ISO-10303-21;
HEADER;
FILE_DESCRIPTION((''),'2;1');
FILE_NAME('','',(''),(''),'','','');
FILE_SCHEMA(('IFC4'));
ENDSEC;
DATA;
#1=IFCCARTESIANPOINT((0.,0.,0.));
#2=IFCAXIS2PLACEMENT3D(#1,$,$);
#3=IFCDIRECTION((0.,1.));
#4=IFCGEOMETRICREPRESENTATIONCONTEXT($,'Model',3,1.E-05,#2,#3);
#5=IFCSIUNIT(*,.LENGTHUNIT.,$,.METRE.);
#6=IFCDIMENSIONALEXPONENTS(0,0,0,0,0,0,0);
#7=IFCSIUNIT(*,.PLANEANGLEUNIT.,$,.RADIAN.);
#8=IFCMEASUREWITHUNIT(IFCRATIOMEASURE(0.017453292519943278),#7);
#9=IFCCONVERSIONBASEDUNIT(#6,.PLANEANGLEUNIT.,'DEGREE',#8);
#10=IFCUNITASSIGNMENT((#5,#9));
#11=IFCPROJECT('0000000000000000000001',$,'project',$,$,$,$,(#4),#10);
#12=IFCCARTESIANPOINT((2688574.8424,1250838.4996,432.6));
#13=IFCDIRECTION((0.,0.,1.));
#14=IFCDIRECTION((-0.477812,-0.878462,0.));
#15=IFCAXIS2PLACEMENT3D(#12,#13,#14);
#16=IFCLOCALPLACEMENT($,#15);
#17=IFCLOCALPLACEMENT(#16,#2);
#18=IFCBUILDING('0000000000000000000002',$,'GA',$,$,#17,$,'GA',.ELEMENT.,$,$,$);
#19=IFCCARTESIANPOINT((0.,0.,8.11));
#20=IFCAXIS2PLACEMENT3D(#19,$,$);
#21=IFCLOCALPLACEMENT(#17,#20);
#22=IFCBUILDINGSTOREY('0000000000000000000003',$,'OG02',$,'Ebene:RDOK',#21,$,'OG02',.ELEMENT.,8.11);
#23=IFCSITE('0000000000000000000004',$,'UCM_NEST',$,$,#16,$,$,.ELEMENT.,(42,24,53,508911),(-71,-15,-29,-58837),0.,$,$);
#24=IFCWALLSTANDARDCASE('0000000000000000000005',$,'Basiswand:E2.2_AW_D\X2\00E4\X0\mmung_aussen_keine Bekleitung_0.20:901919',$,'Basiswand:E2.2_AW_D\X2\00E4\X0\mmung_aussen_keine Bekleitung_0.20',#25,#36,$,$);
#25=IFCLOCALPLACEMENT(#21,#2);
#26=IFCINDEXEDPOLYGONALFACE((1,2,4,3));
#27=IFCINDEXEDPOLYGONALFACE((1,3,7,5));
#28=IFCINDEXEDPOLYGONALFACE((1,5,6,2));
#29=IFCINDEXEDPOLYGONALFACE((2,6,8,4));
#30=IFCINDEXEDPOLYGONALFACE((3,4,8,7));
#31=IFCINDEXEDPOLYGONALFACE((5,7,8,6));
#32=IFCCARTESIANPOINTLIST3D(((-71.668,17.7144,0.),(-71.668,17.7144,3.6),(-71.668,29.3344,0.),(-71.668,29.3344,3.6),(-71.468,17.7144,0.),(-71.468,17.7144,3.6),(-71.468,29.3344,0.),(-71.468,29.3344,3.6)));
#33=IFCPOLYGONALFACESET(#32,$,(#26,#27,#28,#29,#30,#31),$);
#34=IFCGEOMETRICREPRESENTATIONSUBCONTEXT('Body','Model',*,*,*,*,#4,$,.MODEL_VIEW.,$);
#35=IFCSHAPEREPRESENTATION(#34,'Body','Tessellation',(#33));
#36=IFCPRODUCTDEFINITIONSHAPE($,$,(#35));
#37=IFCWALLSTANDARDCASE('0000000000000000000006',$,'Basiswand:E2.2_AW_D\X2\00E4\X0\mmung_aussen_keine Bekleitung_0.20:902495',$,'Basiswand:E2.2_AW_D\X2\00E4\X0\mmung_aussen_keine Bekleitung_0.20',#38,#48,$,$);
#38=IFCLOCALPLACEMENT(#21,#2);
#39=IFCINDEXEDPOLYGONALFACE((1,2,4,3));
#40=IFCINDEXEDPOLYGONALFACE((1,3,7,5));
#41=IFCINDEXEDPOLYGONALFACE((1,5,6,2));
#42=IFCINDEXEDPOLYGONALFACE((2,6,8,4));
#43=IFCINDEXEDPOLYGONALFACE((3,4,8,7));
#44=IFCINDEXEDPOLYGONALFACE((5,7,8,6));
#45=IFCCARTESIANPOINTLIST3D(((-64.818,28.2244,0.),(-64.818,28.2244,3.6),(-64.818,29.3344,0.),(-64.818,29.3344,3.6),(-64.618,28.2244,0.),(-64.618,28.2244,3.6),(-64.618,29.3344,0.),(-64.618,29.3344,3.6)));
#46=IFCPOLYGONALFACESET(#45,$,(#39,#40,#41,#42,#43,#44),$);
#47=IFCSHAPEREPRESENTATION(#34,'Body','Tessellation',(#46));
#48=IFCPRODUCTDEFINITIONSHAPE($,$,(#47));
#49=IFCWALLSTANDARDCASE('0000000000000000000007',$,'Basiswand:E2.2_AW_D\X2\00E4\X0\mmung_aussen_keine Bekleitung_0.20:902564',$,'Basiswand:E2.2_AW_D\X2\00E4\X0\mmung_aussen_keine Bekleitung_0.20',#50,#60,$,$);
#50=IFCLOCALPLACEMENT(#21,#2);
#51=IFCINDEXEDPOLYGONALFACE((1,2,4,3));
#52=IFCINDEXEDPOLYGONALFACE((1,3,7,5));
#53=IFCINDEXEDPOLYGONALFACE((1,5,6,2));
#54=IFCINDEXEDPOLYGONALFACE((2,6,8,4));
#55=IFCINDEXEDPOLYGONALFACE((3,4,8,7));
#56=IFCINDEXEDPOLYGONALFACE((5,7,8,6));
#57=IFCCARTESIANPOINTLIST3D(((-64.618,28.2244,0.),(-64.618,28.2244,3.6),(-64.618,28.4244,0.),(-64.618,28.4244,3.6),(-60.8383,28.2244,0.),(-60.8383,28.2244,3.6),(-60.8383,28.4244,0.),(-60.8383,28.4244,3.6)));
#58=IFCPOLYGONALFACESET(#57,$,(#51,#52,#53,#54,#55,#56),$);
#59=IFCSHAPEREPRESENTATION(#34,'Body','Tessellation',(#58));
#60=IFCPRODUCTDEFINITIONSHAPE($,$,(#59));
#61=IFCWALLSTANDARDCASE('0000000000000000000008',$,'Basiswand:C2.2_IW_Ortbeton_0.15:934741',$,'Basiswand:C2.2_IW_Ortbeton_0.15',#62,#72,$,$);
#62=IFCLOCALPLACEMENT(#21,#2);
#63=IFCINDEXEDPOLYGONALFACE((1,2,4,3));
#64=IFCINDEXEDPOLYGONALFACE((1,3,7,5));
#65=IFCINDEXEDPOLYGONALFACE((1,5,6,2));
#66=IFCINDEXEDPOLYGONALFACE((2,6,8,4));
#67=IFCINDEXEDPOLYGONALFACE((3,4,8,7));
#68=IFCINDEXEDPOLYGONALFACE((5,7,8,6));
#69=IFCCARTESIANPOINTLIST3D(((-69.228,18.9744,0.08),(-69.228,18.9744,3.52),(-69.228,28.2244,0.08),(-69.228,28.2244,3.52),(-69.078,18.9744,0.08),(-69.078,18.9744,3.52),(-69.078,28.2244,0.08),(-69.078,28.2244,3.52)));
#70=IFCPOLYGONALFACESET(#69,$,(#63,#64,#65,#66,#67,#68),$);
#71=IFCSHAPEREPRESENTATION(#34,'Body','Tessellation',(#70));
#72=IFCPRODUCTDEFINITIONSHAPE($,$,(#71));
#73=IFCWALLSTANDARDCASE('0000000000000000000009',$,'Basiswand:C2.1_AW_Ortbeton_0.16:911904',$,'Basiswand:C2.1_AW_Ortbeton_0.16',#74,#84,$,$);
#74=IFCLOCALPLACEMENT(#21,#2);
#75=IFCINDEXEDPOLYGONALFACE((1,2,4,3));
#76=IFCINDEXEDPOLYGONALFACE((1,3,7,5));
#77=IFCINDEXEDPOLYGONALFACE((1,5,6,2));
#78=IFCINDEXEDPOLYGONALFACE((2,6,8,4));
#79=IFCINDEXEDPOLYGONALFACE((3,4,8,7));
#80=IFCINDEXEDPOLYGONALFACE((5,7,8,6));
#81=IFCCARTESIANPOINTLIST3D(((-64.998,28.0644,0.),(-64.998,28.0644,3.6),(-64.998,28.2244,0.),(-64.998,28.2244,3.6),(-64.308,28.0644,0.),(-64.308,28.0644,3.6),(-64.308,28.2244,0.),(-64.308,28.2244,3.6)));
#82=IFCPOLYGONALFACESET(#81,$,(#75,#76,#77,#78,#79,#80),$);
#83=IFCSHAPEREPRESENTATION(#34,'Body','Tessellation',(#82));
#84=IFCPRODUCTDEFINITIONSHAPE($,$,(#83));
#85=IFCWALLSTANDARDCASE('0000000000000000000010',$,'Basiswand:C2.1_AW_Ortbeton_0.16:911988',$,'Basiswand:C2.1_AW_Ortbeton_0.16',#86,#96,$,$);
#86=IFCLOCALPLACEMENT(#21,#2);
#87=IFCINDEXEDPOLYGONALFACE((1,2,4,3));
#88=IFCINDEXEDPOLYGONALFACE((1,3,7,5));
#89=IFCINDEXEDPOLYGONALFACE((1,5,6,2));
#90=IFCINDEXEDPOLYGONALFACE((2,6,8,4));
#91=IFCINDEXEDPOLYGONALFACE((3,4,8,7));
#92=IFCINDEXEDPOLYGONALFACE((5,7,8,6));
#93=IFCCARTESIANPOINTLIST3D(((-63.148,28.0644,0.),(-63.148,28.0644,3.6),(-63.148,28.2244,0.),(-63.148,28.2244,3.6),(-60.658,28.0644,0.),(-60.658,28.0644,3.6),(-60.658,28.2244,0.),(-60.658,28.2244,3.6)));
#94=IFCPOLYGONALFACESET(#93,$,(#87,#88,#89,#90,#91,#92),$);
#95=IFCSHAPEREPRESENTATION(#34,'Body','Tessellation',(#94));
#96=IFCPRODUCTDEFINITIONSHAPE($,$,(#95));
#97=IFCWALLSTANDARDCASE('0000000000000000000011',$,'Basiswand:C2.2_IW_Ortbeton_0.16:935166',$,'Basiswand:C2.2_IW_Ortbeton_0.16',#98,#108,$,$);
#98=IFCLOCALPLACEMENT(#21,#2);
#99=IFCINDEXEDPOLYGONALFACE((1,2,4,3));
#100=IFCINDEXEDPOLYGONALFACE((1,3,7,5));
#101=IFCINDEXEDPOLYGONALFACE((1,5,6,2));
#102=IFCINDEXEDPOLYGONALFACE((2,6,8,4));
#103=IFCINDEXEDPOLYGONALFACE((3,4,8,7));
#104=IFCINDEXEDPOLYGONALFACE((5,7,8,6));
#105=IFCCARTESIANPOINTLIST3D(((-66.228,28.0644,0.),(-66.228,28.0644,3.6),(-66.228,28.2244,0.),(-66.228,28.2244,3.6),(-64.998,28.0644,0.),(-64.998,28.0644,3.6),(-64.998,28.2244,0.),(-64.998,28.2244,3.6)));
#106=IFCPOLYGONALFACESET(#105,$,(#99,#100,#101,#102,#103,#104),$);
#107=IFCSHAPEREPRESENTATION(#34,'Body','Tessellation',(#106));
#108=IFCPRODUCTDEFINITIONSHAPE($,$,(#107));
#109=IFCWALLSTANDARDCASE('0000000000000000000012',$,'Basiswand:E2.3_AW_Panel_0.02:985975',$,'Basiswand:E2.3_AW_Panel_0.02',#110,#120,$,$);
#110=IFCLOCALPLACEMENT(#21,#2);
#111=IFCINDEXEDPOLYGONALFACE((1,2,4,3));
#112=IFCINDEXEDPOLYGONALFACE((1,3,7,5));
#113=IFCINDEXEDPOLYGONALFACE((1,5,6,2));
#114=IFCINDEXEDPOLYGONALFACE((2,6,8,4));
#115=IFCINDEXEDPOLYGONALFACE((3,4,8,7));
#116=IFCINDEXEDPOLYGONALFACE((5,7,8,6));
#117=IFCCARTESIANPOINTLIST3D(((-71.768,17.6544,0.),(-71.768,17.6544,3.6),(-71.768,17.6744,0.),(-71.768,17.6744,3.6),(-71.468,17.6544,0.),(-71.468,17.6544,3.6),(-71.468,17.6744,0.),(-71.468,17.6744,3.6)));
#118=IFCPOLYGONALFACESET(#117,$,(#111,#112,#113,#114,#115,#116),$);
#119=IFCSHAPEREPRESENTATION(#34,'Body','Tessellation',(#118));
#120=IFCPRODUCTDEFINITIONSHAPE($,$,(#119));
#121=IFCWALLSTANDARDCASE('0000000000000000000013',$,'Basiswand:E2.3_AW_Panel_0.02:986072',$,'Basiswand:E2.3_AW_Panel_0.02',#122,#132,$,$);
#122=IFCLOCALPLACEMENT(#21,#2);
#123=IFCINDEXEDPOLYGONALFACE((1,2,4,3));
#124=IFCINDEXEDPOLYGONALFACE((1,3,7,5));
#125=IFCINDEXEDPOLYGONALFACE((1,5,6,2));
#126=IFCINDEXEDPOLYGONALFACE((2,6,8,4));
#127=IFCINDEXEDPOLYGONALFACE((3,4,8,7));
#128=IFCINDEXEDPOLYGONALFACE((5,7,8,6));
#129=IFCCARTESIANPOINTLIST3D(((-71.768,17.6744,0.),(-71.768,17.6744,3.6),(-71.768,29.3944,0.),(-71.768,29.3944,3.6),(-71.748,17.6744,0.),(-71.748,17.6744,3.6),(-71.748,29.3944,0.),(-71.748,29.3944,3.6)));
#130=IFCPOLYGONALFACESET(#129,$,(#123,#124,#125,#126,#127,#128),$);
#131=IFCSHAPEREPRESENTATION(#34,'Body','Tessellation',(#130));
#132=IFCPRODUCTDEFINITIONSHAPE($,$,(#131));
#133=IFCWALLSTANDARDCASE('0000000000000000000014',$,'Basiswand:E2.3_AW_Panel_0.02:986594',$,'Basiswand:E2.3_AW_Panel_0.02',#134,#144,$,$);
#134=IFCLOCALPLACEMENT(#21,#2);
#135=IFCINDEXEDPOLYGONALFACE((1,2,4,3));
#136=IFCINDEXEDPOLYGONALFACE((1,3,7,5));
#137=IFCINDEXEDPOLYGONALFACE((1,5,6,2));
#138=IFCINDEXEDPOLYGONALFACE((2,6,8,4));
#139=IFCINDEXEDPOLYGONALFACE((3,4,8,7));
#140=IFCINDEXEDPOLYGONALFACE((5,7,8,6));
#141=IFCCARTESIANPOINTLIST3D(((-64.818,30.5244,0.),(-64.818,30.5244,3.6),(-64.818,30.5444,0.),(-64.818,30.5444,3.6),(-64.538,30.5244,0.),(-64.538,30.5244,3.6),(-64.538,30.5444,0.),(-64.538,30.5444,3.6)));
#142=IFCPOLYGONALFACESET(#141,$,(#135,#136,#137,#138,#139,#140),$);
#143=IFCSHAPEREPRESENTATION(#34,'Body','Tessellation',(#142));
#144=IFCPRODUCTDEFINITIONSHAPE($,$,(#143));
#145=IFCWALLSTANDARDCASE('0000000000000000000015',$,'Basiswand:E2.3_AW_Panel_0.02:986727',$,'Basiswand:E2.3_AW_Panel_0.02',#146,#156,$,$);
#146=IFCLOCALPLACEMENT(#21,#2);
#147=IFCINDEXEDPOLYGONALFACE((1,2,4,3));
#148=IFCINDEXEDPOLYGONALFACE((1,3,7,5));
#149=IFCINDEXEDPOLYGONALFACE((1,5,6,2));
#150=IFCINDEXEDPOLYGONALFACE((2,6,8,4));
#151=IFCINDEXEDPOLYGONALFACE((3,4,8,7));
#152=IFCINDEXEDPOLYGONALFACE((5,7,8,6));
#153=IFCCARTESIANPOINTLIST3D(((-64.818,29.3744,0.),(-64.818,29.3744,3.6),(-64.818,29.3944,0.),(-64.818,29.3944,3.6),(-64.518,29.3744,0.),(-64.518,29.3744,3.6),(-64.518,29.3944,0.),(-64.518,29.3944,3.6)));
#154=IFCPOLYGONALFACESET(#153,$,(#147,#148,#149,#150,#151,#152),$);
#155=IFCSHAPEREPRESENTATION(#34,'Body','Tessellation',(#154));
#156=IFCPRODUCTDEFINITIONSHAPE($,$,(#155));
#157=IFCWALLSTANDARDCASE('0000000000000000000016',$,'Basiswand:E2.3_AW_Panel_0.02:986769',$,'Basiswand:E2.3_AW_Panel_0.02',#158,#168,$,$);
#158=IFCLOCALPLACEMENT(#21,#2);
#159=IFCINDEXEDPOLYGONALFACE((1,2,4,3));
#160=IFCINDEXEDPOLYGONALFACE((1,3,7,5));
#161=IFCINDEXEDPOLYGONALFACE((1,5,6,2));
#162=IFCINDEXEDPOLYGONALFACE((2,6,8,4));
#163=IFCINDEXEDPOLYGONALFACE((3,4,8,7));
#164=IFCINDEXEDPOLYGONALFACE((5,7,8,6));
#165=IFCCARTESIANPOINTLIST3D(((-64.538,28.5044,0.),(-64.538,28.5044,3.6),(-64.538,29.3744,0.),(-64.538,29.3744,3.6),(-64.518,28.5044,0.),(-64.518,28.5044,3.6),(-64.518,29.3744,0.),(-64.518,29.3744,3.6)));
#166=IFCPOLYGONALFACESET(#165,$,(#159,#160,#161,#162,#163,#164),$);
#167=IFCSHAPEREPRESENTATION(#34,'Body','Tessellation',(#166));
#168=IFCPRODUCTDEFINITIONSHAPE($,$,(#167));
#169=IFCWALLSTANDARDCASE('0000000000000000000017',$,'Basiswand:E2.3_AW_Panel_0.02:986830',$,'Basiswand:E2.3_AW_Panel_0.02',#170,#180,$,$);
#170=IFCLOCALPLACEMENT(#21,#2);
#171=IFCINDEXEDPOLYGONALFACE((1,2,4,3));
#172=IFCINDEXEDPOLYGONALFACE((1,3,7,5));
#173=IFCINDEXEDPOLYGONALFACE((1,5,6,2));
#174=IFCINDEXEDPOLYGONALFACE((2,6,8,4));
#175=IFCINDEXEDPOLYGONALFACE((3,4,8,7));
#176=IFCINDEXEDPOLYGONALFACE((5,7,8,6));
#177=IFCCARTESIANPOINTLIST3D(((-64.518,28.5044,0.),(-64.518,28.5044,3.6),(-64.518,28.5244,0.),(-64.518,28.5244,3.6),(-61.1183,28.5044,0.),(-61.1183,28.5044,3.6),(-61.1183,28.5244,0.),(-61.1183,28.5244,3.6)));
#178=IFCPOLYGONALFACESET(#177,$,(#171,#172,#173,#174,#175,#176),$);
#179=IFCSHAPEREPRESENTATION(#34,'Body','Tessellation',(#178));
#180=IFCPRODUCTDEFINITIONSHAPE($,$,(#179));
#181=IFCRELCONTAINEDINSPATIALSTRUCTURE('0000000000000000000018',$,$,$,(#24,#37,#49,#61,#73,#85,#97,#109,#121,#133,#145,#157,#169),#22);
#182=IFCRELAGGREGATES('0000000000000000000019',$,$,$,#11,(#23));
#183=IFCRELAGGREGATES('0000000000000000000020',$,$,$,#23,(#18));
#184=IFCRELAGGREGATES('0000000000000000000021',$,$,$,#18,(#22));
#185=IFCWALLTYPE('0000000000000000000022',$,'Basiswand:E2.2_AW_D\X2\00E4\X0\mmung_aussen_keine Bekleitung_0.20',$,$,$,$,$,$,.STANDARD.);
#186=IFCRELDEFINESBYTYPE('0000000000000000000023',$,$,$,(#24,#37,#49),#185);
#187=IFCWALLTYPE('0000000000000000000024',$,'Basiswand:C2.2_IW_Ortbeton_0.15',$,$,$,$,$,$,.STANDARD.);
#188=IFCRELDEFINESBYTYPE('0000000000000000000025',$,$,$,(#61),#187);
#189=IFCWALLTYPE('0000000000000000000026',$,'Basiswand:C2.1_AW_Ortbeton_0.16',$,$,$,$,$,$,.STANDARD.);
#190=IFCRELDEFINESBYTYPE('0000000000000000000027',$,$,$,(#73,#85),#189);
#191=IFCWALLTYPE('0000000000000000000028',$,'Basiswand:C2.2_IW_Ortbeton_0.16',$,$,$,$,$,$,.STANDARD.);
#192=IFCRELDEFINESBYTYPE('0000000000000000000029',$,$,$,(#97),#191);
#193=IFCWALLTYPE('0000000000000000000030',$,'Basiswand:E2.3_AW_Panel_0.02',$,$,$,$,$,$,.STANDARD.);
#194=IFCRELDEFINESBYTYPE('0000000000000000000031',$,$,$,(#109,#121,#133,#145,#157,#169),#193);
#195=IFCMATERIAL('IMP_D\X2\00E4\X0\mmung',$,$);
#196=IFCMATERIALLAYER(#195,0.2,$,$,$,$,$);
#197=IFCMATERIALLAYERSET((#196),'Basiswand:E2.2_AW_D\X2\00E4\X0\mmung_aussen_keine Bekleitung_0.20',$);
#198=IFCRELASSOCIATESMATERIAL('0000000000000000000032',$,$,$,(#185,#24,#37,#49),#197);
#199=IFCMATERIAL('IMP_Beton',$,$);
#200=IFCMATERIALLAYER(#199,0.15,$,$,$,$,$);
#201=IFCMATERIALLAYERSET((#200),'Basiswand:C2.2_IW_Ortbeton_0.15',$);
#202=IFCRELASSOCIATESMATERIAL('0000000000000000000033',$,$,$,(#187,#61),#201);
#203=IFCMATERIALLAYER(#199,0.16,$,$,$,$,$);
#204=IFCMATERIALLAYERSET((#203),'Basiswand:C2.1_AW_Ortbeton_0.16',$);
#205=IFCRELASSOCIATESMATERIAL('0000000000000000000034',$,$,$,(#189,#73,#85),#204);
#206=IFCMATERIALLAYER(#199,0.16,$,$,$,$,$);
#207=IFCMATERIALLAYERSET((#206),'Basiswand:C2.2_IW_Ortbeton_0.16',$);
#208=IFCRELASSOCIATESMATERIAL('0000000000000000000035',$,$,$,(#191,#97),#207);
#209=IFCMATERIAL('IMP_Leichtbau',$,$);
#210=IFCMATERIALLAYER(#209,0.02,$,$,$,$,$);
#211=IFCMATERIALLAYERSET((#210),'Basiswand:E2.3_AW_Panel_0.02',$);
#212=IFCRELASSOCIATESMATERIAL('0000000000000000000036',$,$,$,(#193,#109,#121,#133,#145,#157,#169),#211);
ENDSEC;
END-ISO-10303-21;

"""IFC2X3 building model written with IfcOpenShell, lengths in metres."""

from ifc_helpers import new_model, entity, si_unit, converted_unit, direction, frame, frame_2d, origin, place, context, subcontext, project, spatial, polyline, rectangle, extrude, clip, bounded_halfspace, material, layer, layer_set, layer_usage, type_object, element, save


model = new_model("IFC2X3")

# Units and contexts
model_context = context("Model", 3, precision=1e-05, world=origin(), true_north=direction((0.0, 1.0)))
body_context = subcontext(model_context, "Body", "Model", "MODEL_VIEW")
ifc_project = project(units=[si_unit("LENGTHUNIT", "METRE"), converted_unit("PLANEANGLEUNIT", "DEGREE", entity("IfcRatioMeasure", 0.017453292519943278), si_unit("PLANEANGLEUNIT", "RADIAN"), dimensions=[0, 0, 0, 0, 0, 0, 0])], contexts=[model_context])

# Site, building, storey
site_placement = place(None, frame((2688574.8424, 1250838.4996, 432.6), z_axis=(0.0, 0.0, 1.0), x_axis=(-0.477812, -0.878462, 0.0)))
site = spatial("IfcSite", under=ifc_project, at=site_placement, Name="UCM_NEST", CompositionType="ELEMENT", RefLatitude=(42, 24, 53, 508911), RefLongitude=(-71, -15, -29, -58837), RefElevation=0.0)
building_placement = place(site_placement, origin())
building = spatial("IfcBuilding", under=site, at=building_placement, Name="GA", LongName="GA", CompositionType="ELEMENT")
storey_placement = place(building_placement, frame((0.0, 0.0, 8.11)))
storey = spatial("IfcBuildingStorey", under=building, at=storey_placement, Name="OG02", ObjectType="Ebene:RDOK", LongName="OG02", CompositionType="ELEMENT", Elevation=8.11)

# Walls
ifc_material_1 = material(Name="IMP_Dämmung")
ifc_layer_1 = layer(ifc_material_1, 0.2)
ifc_layer_set_1 = layer_set([ifc_layer_1], Name="Basiswand:E2.2_AW_Dämmung_aussen_keine Bekleitung_0.20")
ifc_layer_usage_1 = layer_usage(ifc_layer_set_1, "AXIS2", "NEGATIVE", 0.1)
wall_type_1 = type_object("IfcWallType", Name="Basiswand:E2.2_AW_Dämmung_aussen_keine Bekleitung_0.20", PredefinedType="STANDARD", material=ifc_layer_set_1)
wall_1_placement = place(storey_placement, frame((-71.568, 17.7144, 0.0), z_axis=(0.0, 0.0, 1.0), x_axis=(0.0, 1.0, 0.0)))
element("IfcWallStandardCase", 1, at=wall_1_placement, inside=storey, type_object=wall_type_1, material=ifc_layer_usage_1, Name="Basiswand:E2.2_AW_Dämmung_aussen_keine Bekleitung_0.20:901919", ObjectType="Basiswand:E2.2_AW_Dämmung_aussen_keine Bekleitung_0.20", context=body_context, shape_type="SweptSolid", body=[
    extrude(rectangle(XDim=11.62, YDim=0.2, at=frame_2d((5.81, 0.0), x_axis=(-1.0, 0.0))), origin(), (0.0, 0.0, 1.0), 3.6),
])
wall_2_placement = place(storey_placement, frame((-64.718, 29.3344, 0.0), z_axis=(0.0, 0.0, 1.0), x_axis=(0.0, -1.0, 0.0)))
element("IfcWallStandardCase", 2, at=wall_2_placement, inside=storey, type_object=wall_type_1, material=ifc_layer_usage_1, Name="Basiswand:E2.2_AW_Dämmung_aussen_keine Bekleitung_0.20:902495", ObjectType="Basiswand:E2.2_AW_Dämmung_aussen_keine Bekleitung_0.20", context=body_context, shape_type="SweptSolid", body=[
    extrude(rectangle(XDim=1.11, YDim=0.2, at=frame_2d((0.555, 0.0), x_axis=(-1.0, 0.0))), origin(), (0.0, 0.0, 1.0), 3.6),
])
wall_3_placement = place(storey_placement, frame((-64.618, 28.3244, 0.0)))
element("IfcWallStandardCase", 3, at=wall_3_placement, inside=storey, type_object=wall_type_1, material=ifc_layer_usage_1, Name="Basiswand:E2.2_AW_Dämmung_aussen_keine Bekleitung_0.20:902564", ObjectType="Basiswand:E2.2_AW_Dämmung_aussen_keine Bekleitung_0.20", context=body_context, shape_type="SweptSolid", body=[
    extrude(rectangle(XDim=3.7797, YDim=0.2, at=frame_2d((1.8899, 0.0), x_axis=(-1.0, 0.0))), origin(), (0.0, 0.0, 1.0), 3.6),
])

# Shared definitions
ifc_material_2 = material(Name="IMP_Beton")
ifc_layer_2 = layer(ifc_material_2, 0.15)
ifc_layer_set_2 = layer_set([ifc_layer_2], Name="Basiswand:C2.2_IW_Ortbeton_0.15")
ifc_layer_usage_2 = layer_usage(ifc_layer_set_2, "AXIS2", "NEGATIVE", 0.075)
wall_type_2 = type_object("IfcWallType", Name="Basiswand:C2.2_IW_Ortbeton_0.15", PredefinedType="STANDARD", material=ifc_layer_set_2)

# Wall
wall_4_placement = place(storey_placement, frame((-69.153, 18.9744, 0.08), z_axis=(0.0, 0.0, 1.0), x_axis=(0.0, 1.0, 0.0)))
element("IfcWallStandardCase", 4, at=wall_4_placement, inside=storey, type_object=wall_type_2, material=ifc_layer_usage_2, Name="Basiswand:C2.2_IW_Ortbeton_0.15:934741", ObjectType="Basiswand:C2.2_IW_Ortbeton_0.15", context=body_context, shape_type="Clipping", body=[
    clip(clip(extrude(rectangle(XDim=9.25, YDim=0.15, at=frame_2d((4.625, 0.0), x_axis=(-1.0, 0.0))), origin(), (0.0, 0.0, 1.0), 3.44), bounded_halfspace(frame((9.25, -0.075, 0.0), z_axis=(0.0, 0.0, 1.0), x_axis=(0.0, 1.0, 0.0)), True, frame((9.25, -0.075, 0.0), z_axis=(0.0, 0.0, 1.0), x_axis=(0.0, 1.0, 0.0)), polyline([(0.0, 0.0), (0.15, 0.0), (0.15, 0.15), (0.15, 9.25), (0.0, 9.25), (0.0, 0.0)]))), bounded_halfspace(frame((0.0, -0.075, 3.44), z_axis=(0.0, 0.0, -1.0), x_axis=(0.0, 1.0, 0.0)), True, frame((0.0, -0.075, 3.44), z_axis=(0.0, 0.0, -1.0), x_axis=(0.0, 1.0, 0.0)), polyline([(0.0, 0.0), (0.15, 0.0), (0.15, 9.1), (0.15, 9.25), (0.0, 9.25), (0.0, 0.0)]))),
])

# Walls
ifc_layer_3 = layer(ifc_material_2, 0.16)
ifc_layer_set_3 = layer_set([ifc_layer_3], Name="Basiswand:C2.1_AW_Ortbeton_0.16")
ifc_layer_usage_3 = layer_usage(ifc_layer_set_3, "AXIS2", "NEGATIVE", 0.08)
wall_type_3 = type_object("IfcWallType", Name="Basiswand:C2.1_AW_Ortbeton_0.16", PredefinedType="STANDARD", material=ifc_layer_set_3)
wall_5_placement = place(storey_placement, frame((-64.998, 28.1444, 0.0)))
element("IfcWallStandardCase", 5, at=wall_5_placement, inside=storey, type_object=wall_type_3, material=ifc_layer_usage_3, Name="Basiswand:C2.1_AW_Ortbeton_0.16:911904", ObjectType="Basiswand:C2.1_AW_Ortbeton_0.16", context=body_context, shape_type="SweptSolid", body=[
    extrude(rectangle(XDim=0.69, YDim=0.16, at=frame_2d((0.345, 0.0), x_axis=(-1.0, 0.0))), origin(), (0.0, 0.0, 1.0), 3.6),
])
wall_6_placement = place(storey_placement, frame((-63.148, 28.1444, 0.0)))
element("IfcWallStandardCase", 6, at=wall_6_placement, inside=storey, type_object=wall_type_3, material=ifc_layer_usage_3, Name="Basiswand:C2.1_AW_Ortbeton_0.16:911988", ObjectType="Basiswand:C2.1_AW_Ortbeton_0.16", context=body_context, shape_type="SweptSolid", body=[
    extrude(rectangle(XDim=2.49, YDim=0.16, at=frame_2d((1.245, 0.0), x_axis=(-1.0, 0.0))), origin(), (0.0, 0.0, 1.0), 3.6),
])
ifc_layer_4 = layer(ifc_material_2, 0.16)
ifc_layer_set_4 = layer_set([ifc_layer_4], Name="Basiswand:C2.2_IW_Ortbeton_0.16")
ifc_layer_usage_4 = layer_usage(ifc_layer_set_4, "AXIS2", "NEGATIVE", 0.08)
wall_type_4 = type_object("IfcWallType", Name="Basiswand:C2.2_IW_Ortbeton_0.16", PredefinedType="STANDARD", material=ifc_layer_set_4)
wall_7_placement = place(storey_placement, frame((-66.228, 28.1444, 0.0)))
element("IfcWallStandardCase", 7, at=wall_7_placement, inside=storey, type_object=wall_type_4, material=ifc_layer_usage_4, Name="Basiswand:C2.2_IW_Ortbeton_0.16:935166", ObjectType="Basiswand:C2.2_IW_Ortbeton_0.16", context=body_context, shape_type="SweptSolid", body=[
    extrude(rectangle(XDim=1.23, YDim=0.16, at=frame_2d((0.615, 0.0), x_axis=(-1.0, 0.0))), origin(), (0.0, 0.0, 1.0), 3.6),
])
ifc_material_3 = material(Name="IMP_Leichtbau")
ifc_layer_5 = layer(ifc_material_3, 0.02)
ifc_layer_set_5 = layer_set([ifc_layer_5], Name="Basiswand:E2.3_AW_Panel_0.02")
ifc_layer_usage_5 = layer_usage(ifc_layer_set_5, "AXIS2", "NEGATIVE", 0.01)
wall_type_5 = type_object("IfcWallType", Name="Basiswand:E2.3_AW_Panel_0.02", PredefinedType="STANDARD", material=ifc_layer_set_5)
wall_8_placement = place(storey_placement, frame((-71.468, 17.6644, 0.0), z_axis=(0.0, 0.0, 1.0), x_axis=(-1.0, 0.0, 0.0)))
element("IfcWallStandardCase", 8, at=wall_8_placement, inside=storey, type_object=wall_type_5, material=ifc_layer_usage_5, Name="Basiswand:E2.3_AW_Panel_0.02:985975", ObjectType="Basiswand:E2.3_AW_Panel_0.02", context=body_context, shape_type="SweptSolid", body=[
    extrude(rectangle(XDim=0.3, YDim=0.02, at=frame_2d((0.15, 0.0), x_axis=(-1.0, 0.0))), origin(), (0.0, 0.0, 1.0), 3.6),
])
wall_9_placement = place(storey_placement, frame((-71.758, 17.6744, 0.0), z_axis=(0.0, 0.0, 1.0), x_axis=(0.0, 1.0, 0.0)))
element("IfcWallStandardCase", 9, at=wall_9_placement, inside=storey, type_object=wall_type_5, material=ifc_layer_usage_5, Name="Basiswand:E2.3_AW_Panel_0.02:986072", ObjectType="Basiswand:E2.3_AW_Panel_0.02", context=body_context, shape_type="SweptSolid", body=[
    extrude(rectangle(XDim=11.72, YDim=0.02, at=frame_2d((5.86, 0.0), x_axis=(-1.0, 0.0))), origin(), (0.0, 0.0, 1.0), 3.6),
])
wall_10_placement = place(storey_placement, frame((-64.538, 30.5344, 0.0), z_axis=(0.0, 0.0, 1.0), x_axis=(-1.0, 0.0, 0.0)))
element("IfcWallStandardCase", 10, at=wall_10_placement, inside=storey, type_object=wall_type_5, material=ifc_layer_usage_5, Name="Basiswand:E2.3_AW_Panel_0.02:986594", ObjectType="Basiswand:E2.3_AW_Panel_0.02", context=body_context, shape_type="SweptSolid", body=[
    extrude(rectangle(XDim=0.28, YDim=0.02, at=frame_2d((0.14, 0.0), x_axis=(-1.0, 0.0))), origin(), (0.0, 0.0, 1.0), 3.6),
])
wall_11_placement = place(storey_placement, frame((-64.818, 29.3844, 0.0)))
element("IfcWallStandardCase", 11, at=wall_11_placement, inside=storey, type_object=wall_type_5, material=ifc_layer_usage_5, Name="Basiswand:E2.3_AW_Panel_0.02:986727", ObjectType="Basiswand:E2.3_AW_Panel_0.02", context=body_context, shape_type="SweptSolid", body=[
    extrude(rectangle(XDim=0.3, YDim=0.02, at=frame_2d((0.15, 0.0), x_axis=(-1.0, 0.0))), origin(), (0.0, 0.0, 1.0), 3.6),
])
wall_12_placement = place(storey_placement, frame((-64.528, 29.3744, 0.0), z_axis=(0.0, 0.0, 1.0), x_axis=(0.0, -1.0, 0.0)))
element("IfcWallStandardCase", 12, at=wall_12_placement, inside=storey, type_object=wall_type_5, material=ifc_layer_usage_5, Name="Basiswand:E2.3_AW_Panel_0.02:986769", ObjectType="Basiswand:E2.3_AW_Panel_0.02", context=body_context, shape_type="SweptSolid", body=[
    extrude(rectangle(XDim=0.87, YDim=0.02, at=frame_2d((0.435, 0.0), x_axis=(-1.0, 0.0))), origin(), (0.0, 0.0, 1.0), 3.6),
])
wall_13_placement = place(storey_placement, frame((-64.518, 28.5144, 0.0)))
element("IfcWallStandardCase", 13, at=wall_13_placement, inside=storey, type_object=wall_type_5, material=ifc_layer_usage_5, Name="Basiswand:E2.3_AW_Panel_0.02:986830", ObjectType="Basiswand:E2.3_AW_Panel_0.02", context=body_context, shape_type="SweptSolid", body=[
    extrude(rectangle(XDim=3.3997, YDim=0.02, at=frame_2d((1.6999, 0.0), x_axis=(-1.0, 0.0))), origin(), (0.0, 0.0, 1.0), 3.6),
])

save(model, "model.ifc")
